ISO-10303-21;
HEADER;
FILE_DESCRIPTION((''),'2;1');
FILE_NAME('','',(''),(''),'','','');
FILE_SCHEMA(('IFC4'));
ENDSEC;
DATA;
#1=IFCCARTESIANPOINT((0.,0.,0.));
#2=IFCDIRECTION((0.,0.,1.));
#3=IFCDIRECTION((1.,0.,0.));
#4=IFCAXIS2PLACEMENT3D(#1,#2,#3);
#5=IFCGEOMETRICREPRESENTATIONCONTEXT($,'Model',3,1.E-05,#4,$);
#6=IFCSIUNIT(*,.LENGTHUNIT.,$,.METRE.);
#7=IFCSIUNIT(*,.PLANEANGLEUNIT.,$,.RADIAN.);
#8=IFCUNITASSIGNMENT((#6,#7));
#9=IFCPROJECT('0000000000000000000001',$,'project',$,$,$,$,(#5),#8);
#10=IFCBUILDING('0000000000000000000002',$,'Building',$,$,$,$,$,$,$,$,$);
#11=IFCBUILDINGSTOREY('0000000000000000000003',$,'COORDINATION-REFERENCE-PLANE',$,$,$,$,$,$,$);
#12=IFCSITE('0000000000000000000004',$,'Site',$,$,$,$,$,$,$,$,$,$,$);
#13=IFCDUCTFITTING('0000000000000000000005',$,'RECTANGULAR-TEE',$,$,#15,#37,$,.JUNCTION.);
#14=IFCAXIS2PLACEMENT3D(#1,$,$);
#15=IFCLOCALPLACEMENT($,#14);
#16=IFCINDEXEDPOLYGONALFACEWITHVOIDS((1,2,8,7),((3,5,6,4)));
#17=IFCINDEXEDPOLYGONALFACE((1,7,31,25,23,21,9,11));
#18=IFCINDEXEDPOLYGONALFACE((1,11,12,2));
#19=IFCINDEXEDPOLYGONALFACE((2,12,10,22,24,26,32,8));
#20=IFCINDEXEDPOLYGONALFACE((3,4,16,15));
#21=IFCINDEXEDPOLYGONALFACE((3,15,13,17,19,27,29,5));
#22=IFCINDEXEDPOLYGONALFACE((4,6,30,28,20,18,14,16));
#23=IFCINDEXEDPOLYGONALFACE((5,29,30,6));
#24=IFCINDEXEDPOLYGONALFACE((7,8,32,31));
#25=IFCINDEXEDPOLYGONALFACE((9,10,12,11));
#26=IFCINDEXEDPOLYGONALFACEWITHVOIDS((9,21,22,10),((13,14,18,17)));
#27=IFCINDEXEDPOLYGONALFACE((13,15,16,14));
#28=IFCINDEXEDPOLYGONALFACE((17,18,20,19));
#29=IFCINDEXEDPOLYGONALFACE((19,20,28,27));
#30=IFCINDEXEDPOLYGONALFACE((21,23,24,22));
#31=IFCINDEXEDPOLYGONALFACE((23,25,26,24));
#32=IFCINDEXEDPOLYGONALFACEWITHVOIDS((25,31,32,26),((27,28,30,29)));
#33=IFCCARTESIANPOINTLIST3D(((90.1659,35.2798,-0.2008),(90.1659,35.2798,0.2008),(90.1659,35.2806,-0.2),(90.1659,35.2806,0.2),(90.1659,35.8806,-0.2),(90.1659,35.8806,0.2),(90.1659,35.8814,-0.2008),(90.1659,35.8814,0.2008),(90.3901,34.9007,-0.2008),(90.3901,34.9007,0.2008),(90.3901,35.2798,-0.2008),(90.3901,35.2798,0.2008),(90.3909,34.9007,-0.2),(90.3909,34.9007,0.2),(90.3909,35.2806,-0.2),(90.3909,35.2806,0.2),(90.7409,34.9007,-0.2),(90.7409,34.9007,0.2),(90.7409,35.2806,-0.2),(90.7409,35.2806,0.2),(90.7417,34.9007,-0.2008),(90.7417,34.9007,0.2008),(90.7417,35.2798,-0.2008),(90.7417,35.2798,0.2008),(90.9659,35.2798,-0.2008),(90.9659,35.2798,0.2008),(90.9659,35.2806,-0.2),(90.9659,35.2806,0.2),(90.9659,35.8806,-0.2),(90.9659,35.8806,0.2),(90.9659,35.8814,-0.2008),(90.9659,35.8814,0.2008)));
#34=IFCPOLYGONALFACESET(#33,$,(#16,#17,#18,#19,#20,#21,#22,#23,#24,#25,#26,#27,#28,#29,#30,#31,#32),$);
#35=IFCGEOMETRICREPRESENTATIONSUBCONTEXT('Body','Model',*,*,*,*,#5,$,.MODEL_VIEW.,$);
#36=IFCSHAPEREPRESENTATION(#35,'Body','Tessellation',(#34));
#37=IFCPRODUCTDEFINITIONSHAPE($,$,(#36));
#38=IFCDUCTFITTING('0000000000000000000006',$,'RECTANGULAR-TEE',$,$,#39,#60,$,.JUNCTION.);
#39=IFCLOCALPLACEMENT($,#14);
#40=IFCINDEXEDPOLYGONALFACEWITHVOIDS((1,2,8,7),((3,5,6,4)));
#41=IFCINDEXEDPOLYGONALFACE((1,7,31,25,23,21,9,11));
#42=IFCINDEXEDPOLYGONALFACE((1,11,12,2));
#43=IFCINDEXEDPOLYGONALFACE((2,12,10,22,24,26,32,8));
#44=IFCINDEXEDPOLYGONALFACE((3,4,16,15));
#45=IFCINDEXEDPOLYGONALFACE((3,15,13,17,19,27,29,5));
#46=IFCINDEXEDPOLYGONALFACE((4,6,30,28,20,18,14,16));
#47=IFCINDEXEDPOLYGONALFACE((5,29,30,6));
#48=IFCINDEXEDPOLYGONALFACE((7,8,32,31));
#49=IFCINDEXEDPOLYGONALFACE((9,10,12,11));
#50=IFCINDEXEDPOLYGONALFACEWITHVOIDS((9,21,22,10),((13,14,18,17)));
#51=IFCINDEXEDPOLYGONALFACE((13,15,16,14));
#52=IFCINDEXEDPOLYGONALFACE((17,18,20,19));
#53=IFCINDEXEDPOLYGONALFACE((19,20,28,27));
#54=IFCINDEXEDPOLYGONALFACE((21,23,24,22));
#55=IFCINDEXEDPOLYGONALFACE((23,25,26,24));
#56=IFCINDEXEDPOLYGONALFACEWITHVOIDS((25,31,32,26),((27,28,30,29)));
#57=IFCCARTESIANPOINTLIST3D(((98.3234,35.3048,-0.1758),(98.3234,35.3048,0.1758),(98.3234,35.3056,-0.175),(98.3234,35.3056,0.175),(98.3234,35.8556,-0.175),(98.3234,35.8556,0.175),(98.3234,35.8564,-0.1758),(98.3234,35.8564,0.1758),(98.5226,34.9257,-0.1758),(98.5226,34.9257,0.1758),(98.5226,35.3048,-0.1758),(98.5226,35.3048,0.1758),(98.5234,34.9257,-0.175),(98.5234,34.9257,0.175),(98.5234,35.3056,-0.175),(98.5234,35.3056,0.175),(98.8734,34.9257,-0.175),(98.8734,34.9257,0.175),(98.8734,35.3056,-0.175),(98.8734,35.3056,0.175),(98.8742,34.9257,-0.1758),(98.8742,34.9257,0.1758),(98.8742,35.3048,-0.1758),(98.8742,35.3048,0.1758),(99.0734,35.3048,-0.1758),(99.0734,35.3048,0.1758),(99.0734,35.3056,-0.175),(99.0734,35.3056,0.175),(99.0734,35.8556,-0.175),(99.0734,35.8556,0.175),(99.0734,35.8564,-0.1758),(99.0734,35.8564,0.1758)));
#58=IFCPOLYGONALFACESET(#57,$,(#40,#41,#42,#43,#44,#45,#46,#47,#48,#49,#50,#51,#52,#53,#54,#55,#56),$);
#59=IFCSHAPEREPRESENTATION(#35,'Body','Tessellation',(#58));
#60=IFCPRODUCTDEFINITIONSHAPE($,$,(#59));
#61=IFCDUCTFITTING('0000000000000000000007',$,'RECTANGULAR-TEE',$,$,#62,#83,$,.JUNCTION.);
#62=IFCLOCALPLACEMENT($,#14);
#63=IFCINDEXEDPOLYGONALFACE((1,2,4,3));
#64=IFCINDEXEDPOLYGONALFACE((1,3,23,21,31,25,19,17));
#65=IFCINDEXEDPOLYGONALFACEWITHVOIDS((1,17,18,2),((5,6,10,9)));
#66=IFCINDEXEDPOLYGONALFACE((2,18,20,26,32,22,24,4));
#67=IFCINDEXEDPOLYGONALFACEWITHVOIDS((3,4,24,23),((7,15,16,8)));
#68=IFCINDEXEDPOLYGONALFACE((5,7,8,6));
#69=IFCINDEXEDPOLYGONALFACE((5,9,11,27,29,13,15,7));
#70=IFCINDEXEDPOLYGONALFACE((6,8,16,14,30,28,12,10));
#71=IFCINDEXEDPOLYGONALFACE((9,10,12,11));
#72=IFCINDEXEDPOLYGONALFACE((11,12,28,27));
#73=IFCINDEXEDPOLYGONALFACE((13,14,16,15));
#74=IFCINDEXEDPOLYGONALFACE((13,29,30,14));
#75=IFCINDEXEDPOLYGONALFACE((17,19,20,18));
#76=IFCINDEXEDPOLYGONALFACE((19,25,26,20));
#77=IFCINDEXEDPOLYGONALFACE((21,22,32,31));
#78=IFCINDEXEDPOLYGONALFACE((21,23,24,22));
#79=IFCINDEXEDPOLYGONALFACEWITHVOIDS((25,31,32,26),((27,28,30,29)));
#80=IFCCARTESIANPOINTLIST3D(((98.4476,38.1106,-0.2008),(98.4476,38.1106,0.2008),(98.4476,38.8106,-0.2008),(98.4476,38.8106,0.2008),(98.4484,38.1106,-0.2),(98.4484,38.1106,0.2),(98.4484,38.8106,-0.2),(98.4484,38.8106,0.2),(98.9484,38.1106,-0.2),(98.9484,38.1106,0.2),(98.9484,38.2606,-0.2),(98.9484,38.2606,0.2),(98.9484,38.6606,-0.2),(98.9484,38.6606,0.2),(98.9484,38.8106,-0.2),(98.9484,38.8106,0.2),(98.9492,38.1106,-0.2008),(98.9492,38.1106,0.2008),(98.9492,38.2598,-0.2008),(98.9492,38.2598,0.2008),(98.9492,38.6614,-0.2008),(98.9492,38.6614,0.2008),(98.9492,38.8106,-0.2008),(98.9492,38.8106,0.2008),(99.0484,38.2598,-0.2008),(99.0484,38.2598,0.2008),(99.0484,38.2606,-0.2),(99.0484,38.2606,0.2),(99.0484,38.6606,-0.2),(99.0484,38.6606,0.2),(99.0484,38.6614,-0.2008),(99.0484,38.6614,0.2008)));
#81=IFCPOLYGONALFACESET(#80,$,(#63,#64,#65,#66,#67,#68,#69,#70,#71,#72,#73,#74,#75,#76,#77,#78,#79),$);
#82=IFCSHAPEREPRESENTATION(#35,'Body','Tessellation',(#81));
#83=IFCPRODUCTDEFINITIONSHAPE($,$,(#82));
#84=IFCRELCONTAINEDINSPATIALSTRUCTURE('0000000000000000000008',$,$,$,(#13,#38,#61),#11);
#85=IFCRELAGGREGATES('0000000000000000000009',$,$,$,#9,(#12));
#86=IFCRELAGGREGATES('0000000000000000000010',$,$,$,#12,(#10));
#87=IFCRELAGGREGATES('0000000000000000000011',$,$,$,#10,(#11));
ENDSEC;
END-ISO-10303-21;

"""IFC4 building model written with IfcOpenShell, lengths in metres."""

from ifc_helpers import new_model, si_unit, frame, origin_with_axes, place, context, subcontext, project, spatial, rectangle, extrude, boolean, element, save


model = new_model("IFC4")

# Units and contexts
model_context = context("Model", 3, precision=1e-05, world=origin_with_axes())
body_context = subcontext(model_context, "Body", "Model", "MODEL_VIEW")
ifc_project = project(units=[si_unit("LENGTHUNIT", "METRE"), si_unit("PLANEANGLEUNIT", "RADIAN")], contexts=[model_context])

# Site, building, storey
site = spatial("IfcSite", under=ifc_project, Name="Site")
building = spatial("IfcBuilding", under=site, Name="Building")
storey = spatial("IfcBuildingStorey", under=building, Name="COORDINATION-REFERENCE-PLANE")

# Duct fittings
duct_fitting_1_placement = place(None, frame((90.5659, 35.5806, 0.0), z_axis=(1.0, 0.0, 0.0), x_axis=(0.0, -1.0, 0.0)))
solid_1 = boolean("UNION", extrude(rectangle(XDim=0.6, YDim=0.4), frame((0.0, 0.0, -0.4), z_axis=(0.0, 0.0, 1.0), x_axis=(1.0, 0.0, 0.0)), (0.0, 0.0, 1.0), 0.8), extrude(rectangle(XDim=0.35, YDim=0.4), frame((0.0, 0.0, 0.0), z_axis=(1.0, 0.0, 0.0), x_axis=(0.0, 0.0, -1.0)), (0.0, 0.0, 1.0), 0.6799))
element("IfcDuctFitting", 1, at=duct_fitting_1_placement, inside=storey, Name="RECTANGULAR-TEE", PredefinedType="JUNCTION", context=body_context, shape_type="CSG", body=[
    boolean("DIFFERENCE", boolean("UNION", extrude(rectangle(XDim=0.6016, YDim=0.4016), frame((0.0, 0.0, -0.4), z_axis=(0.0, 0.0, 1.0), x_axis=(1.0, 0.0, 0.0)), (0.0, 0.0, 1.0), 0.8), extrude(rectangle(XDim=0.3516, YDim=0.4016), frame((0.0, 0.0, 0.0), z_axis=(1.0, 0.0, 0.0), x_axis=(0.0, 0.0, -1.0)), (0.0, 0.0, 1.0), 0.6799)), solid_1),
])
duct_fitting_2_placement = place(None, frame((98.6984, 35.5806, 0.0), z_axis=(1.0, 0.0, 0.0), x_axis=(0.0, -1.0, 0.0)))
solid_2 = boolean("UNION", extrude(rectangle(XDim=0.55, YDim=0.35), frame((0.0, 0.0, -0.375), z_axis=(0.0, 0.0, 1.0), x_axis=(1.0, 0.0, 0.0)), (0.0, 0.0, 1.0), 0.75), extrude(rectangle(XDim=0.35, YDim=0.35), frame((0.0, 0.0, 0.0), z_axis=(1.0, 0.0, 0.0), x_axis=(0.0, 0.0, -1.0)), (0.0, 0.0, 1.0), 0.6549))
element("IfcDuctFitting", 2, at=duct_fitting_2_placement, inside=storey, Name="RECTANGULAR-TEE", PredefinedType="JUNCTION", context=body_context, shape_type="CSG", body=[
    boolean("DIFFERENCE", boolean("UNION", extrude(rectangle(XDim=0.5516, YDim=0.3516), frame((0.0, 0.0, -0.375), z_axis=(0.0, 0.0, 1.0), x_axis=(1.0, 0.0, 0.0)), (0.0, 0.0, 1.0), 0.75), extrude(rectangle(XDim=0.3516, YDim=0.3516), frame((0.0, 0.0, 0.0), z_axis=(1.0, 0.0, 0.0), x_axis=(0.0, 0.0, -1.0)), (0.0, 0.0, 1.0), 0.6549)), solid_2),
])
duct_fitting_3_placement = place(None, frame((98.6984, 38.4606, 0.0), z_axis=(0.0, 1.0, 0.0), x_axis=(1.0, 0.0, 0.0)))
solid_3 = boolean("UNION", extrude(rectangle(XDim=0.5, YDim=0.4), frame((0.0, 0.0, -0.35), z_axis=(0.0, 0.0, 1.0), x_axis=(1.0, 0.0, 0.0)), (0.0, 0.0, 1.0), 0.7), extrude(rectangle(XDim=0.4, YDim=0.4), frame((0.0, 0.0, 0.0), z_axis=(1.0, 0.0, 0.0), x_axis=(0.0, 0.0, -1.0)), (0.0, 0.0, 1.0), 0.35))
element("IfcDuctFitting", 3, at=duct_fitting_3_placement, inside=storey, Name="RECTANGULAR-TEE", PredefinedType="JUNCTION", context=body_context, shape_type="CSG", body=[
    boolean("DIFFERENCE", boolean("UNION", extrude(rectangle(XDim=0.5016, YDim=0.4016), frame((0.0, 0.0, -0.35), z_axis=(0.0, 0.0, 1.0), x_axis=(1.0, 0.0, 0.0)), (0.0, 0.0, 1.0), 0.7), extrude(rectangle(XDim=0.4016, YDim=0.4016), frame((0.0, 0.0, 0.0), z_axis=(1.0, 0.0, 0.0), x_axis=(0.0, 0.0, -1.0)), (0.0, 0.0, 1.0), 0.35)), solid_3),
])

save(model, "model.ifc")
